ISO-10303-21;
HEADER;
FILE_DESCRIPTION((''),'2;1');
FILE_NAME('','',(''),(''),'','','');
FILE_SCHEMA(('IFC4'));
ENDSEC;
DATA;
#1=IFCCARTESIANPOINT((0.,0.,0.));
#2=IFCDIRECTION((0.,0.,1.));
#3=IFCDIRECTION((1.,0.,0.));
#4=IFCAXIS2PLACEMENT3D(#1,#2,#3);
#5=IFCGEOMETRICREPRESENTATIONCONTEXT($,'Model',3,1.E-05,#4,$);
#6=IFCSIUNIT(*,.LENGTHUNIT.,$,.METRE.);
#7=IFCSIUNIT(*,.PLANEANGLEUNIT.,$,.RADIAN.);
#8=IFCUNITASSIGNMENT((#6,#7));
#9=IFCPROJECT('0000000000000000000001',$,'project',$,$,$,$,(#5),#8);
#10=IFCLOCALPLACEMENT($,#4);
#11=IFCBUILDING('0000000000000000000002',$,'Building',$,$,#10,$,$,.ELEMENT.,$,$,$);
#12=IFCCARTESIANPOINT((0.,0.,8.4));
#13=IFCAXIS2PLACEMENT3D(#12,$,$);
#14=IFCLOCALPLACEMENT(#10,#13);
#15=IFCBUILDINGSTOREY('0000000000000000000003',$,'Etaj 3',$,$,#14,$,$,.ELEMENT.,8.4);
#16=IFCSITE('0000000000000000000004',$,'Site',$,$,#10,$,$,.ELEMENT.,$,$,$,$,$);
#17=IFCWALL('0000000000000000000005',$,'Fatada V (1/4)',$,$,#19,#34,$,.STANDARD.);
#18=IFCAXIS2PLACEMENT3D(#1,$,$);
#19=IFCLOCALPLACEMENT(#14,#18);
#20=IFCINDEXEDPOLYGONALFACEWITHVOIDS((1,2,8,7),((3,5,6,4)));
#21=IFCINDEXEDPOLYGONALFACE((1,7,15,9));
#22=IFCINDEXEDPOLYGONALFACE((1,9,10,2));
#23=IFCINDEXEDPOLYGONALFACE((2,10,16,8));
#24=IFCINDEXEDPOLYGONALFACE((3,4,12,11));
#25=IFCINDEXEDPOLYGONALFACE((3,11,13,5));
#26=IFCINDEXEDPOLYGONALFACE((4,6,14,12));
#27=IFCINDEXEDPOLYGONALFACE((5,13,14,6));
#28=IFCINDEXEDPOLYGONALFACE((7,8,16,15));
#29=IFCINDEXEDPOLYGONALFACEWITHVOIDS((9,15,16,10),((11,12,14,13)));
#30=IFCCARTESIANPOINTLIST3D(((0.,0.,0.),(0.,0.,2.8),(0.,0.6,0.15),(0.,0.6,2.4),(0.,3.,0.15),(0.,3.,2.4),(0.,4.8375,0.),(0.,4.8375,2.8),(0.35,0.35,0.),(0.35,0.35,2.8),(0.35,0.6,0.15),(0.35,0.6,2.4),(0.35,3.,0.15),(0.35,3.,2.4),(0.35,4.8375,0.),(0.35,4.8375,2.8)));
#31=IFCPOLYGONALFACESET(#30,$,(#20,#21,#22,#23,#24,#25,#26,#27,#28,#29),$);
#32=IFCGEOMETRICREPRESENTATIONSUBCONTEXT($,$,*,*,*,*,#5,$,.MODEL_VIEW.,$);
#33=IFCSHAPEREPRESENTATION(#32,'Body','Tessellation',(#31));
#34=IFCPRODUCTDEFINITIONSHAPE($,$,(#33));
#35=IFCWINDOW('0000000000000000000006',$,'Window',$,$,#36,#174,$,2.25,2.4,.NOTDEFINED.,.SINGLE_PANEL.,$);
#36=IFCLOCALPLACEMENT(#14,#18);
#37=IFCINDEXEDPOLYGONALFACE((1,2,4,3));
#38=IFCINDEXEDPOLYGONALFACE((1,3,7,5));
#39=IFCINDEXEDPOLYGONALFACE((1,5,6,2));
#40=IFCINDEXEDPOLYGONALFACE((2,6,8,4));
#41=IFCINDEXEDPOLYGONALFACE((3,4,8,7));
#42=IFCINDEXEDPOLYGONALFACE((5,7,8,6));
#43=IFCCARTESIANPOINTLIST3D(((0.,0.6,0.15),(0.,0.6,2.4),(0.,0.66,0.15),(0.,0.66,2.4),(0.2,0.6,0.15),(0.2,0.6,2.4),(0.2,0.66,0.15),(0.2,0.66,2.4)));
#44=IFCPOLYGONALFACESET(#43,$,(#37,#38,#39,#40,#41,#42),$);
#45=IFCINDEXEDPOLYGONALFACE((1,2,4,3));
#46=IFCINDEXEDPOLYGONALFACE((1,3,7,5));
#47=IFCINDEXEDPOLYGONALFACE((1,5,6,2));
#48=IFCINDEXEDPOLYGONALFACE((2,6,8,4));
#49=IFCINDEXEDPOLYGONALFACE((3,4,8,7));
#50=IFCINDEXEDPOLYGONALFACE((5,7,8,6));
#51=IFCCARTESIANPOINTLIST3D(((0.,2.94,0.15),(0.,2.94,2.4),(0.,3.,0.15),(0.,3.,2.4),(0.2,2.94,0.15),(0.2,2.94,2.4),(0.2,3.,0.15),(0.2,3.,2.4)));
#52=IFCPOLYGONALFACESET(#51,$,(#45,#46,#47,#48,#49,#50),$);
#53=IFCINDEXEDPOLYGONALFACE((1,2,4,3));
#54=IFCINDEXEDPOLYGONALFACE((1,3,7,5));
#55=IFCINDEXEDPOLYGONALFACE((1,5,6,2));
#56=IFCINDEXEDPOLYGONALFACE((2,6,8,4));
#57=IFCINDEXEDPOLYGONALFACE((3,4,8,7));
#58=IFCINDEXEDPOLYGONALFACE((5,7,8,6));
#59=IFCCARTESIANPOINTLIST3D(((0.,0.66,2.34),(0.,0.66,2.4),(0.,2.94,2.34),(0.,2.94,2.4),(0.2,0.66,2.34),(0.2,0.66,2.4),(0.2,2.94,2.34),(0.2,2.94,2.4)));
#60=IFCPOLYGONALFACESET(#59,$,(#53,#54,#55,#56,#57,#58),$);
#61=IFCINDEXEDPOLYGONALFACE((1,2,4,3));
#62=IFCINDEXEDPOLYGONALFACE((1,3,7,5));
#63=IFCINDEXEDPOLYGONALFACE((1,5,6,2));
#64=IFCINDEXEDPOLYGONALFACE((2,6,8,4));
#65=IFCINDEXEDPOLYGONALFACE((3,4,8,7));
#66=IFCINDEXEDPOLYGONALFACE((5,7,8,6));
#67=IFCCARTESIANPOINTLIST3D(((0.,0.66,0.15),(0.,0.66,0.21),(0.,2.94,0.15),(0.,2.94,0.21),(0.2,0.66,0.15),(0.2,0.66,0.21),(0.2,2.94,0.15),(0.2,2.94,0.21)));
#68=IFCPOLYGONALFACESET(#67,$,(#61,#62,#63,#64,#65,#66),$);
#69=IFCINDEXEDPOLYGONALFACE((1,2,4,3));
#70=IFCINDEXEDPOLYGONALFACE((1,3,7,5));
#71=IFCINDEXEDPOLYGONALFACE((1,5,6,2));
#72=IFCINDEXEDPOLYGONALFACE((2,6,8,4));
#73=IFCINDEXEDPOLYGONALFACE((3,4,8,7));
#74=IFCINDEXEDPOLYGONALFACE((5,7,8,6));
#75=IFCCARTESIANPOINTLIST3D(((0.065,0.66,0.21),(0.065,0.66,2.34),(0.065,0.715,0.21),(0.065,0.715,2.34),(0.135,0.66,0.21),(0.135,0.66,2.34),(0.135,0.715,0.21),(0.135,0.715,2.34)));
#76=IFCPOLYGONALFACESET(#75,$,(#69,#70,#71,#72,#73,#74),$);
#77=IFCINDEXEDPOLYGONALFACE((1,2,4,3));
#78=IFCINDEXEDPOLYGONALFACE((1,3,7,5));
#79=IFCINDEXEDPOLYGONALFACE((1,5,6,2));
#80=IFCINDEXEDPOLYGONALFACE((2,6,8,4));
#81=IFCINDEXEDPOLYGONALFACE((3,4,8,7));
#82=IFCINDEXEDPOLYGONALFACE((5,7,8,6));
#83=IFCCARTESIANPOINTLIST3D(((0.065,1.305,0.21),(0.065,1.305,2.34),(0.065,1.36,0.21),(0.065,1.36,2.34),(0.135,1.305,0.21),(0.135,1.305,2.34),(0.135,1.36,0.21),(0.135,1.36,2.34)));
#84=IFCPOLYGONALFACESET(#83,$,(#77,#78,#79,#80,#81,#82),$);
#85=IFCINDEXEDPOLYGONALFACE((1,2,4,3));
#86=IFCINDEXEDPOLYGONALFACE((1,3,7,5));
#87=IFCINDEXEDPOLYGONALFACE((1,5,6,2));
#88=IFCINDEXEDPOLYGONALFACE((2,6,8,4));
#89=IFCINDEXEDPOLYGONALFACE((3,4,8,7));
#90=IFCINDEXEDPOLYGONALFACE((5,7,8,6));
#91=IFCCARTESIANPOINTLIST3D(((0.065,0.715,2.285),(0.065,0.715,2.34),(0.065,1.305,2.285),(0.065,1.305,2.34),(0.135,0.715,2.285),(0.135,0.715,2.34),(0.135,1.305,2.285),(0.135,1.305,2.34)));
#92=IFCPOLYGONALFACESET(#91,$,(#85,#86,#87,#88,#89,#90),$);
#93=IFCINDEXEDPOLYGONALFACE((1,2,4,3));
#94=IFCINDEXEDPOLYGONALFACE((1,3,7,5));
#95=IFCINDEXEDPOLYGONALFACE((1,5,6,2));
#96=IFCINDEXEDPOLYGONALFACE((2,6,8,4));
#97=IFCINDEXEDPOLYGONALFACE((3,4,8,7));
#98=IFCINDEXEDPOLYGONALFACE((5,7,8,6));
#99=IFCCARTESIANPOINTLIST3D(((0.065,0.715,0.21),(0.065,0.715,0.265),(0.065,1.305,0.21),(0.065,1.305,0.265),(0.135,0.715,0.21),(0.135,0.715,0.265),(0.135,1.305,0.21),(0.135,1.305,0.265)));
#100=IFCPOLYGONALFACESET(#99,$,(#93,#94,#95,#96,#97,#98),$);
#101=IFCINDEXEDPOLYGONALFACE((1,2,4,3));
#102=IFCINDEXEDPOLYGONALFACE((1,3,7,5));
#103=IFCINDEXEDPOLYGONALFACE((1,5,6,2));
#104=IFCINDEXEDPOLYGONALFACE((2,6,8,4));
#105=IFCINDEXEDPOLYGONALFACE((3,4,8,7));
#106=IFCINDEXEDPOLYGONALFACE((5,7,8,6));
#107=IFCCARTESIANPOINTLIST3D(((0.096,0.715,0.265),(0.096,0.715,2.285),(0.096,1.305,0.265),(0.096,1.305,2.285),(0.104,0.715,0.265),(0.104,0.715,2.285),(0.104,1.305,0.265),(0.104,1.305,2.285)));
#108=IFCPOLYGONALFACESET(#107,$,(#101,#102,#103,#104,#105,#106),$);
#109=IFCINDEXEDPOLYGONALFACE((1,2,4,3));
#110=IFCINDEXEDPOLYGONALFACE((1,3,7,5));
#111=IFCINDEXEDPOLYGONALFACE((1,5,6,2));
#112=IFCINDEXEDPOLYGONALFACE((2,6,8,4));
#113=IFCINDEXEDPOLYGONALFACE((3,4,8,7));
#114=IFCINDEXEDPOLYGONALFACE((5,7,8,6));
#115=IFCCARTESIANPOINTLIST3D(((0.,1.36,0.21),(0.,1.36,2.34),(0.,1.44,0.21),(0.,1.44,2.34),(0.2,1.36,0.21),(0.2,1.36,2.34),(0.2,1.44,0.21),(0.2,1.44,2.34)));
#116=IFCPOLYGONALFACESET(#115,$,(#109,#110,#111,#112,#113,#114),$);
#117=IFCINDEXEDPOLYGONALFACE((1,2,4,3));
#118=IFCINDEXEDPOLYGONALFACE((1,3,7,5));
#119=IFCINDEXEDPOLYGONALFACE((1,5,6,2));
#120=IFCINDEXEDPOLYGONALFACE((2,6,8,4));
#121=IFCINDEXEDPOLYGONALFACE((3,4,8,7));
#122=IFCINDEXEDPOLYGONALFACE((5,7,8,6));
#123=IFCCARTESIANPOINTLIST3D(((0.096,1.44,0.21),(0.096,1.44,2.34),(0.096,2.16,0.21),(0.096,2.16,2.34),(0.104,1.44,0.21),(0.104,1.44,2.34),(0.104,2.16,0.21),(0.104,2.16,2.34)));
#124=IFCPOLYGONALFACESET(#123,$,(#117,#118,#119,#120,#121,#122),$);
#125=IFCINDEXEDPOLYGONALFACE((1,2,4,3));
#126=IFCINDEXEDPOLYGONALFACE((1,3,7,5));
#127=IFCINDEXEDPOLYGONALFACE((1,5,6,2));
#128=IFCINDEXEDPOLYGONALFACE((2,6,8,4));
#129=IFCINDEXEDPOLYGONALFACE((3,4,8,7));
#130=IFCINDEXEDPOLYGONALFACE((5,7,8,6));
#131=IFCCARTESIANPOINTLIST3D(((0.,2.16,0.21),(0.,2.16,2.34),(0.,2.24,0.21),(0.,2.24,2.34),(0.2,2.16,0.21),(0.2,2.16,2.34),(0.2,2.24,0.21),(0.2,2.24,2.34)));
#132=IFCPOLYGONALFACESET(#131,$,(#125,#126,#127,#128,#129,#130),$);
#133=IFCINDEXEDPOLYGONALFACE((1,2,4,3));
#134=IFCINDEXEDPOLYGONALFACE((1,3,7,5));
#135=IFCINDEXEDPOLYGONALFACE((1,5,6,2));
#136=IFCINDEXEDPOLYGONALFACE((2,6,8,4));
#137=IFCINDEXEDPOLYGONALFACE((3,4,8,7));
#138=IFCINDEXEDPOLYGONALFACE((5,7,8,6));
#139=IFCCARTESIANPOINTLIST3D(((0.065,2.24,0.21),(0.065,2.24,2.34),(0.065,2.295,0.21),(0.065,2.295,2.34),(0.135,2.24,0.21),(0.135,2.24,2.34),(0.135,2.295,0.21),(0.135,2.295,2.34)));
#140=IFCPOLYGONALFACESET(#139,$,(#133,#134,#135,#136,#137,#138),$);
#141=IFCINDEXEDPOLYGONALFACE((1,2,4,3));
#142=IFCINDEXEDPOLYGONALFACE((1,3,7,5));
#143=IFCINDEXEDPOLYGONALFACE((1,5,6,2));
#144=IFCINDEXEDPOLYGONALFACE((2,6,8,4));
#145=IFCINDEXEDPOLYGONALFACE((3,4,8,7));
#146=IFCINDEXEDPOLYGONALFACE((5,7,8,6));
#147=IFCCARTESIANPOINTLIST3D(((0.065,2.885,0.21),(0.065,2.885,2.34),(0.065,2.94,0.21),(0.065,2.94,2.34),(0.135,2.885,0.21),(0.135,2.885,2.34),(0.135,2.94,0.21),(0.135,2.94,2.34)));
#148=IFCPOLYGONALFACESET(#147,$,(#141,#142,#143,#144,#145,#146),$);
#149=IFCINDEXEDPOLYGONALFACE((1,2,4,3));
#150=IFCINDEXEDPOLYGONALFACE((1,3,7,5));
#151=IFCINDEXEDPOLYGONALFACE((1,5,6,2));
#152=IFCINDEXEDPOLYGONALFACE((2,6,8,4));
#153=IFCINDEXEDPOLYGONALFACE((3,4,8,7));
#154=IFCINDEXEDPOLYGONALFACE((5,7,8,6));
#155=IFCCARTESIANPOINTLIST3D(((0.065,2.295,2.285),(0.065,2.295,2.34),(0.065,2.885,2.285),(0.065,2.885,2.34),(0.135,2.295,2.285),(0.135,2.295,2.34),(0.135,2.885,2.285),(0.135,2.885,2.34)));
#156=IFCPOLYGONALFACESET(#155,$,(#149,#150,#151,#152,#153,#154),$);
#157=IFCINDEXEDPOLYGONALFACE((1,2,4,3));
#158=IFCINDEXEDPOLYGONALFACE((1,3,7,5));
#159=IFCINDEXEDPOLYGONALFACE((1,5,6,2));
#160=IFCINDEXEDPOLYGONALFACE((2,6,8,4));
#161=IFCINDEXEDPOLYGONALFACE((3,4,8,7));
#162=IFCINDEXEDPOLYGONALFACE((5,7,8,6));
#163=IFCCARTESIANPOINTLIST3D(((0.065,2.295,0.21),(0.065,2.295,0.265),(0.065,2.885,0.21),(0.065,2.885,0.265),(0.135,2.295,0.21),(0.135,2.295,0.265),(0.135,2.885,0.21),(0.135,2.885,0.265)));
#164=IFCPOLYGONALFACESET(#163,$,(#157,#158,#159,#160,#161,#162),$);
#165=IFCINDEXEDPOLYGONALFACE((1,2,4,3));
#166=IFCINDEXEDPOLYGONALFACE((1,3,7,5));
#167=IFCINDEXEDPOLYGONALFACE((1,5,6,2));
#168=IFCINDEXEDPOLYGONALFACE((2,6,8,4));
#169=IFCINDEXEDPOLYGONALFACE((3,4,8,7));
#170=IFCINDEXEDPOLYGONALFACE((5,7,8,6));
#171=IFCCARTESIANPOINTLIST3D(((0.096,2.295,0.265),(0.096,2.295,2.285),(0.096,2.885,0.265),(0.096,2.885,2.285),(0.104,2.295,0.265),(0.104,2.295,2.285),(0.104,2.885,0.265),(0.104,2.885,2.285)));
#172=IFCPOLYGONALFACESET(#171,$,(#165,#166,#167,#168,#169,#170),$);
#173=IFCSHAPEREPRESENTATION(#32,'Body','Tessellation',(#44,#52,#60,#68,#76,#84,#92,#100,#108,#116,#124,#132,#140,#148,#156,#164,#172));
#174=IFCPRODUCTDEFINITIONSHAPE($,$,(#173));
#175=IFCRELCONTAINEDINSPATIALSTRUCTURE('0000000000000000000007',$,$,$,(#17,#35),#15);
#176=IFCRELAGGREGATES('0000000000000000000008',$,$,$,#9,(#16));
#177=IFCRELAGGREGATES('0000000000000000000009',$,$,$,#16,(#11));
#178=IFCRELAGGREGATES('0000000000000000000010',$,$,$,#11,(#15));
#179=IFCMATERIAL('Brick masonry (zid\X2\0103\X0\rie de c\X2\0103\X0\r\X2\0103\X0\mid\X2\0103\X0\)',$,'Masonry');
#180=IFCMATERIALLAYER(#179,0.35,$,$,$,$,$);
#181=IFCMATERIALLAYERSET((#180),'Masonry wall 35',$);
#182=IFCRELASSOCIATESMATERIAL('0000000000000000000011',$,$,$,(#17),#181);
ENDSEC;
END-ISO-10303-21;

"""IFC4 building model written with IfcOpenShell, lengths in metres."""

from ifc_helpers import new_model, si_unit, frame, frame_2d, origin, origin_with_axes, origin_2d, place, context, subcontext, project, spatial, rectangle, extrude, clip, halfspace, material, layer, layer_set, layer_usage, element, fill, save


model = new_model("IFC4")

# Units and contexts
model_context = context("Model", 3, precision=1e-05, world=origin_with_axes())
sub_context = subcontext(model_context, None, None, "MODEL_VIEW")
ifc_project = project(units=[si_unit("LENGTHUNIT", "METRE"), si_unit("PLANEANGLEUNIT", "RADIAN")], contexts=[model_context])

# Site, building, storey
placement = place(None, origin_with_axes())
site = spatial("IfcSite", under=ifc_project, at=placement, Name="Site", CompositionType="ELEMENT")
building = spatial("IfcBuilding", under=site, at=placement, Name="Building", CompositionType="ELEMENT")
storey_placement = place(placement, frame((0.0, 0.0, 8.4)))
storey = spatial("IfcBuildingStorey", under=building, at=storey_placement, Name="Etaj 3", CompositionType="ELEMENT", Elevation=8.4)

# Wall, opening, window
ifc_material_1 = material(Name="Brick masonry (zidărie de cărămidă)", Category="Masonry")
ifc_layer_1 = layer(ifc_material_1, 0.35)
ifc_layer_set_1 = layer_set([ifc_layer_1], Name="Masonry wall 35")
ifc_layer_usage_1 = layer_usage(ifc_layer_set_1, "AXIS2", "POSITIVE", -0.175)
wall_1_placement = place(storey_placement, frame((0.175, 0.0, 0.0), x_axis=(0.0, 1.0, 0.0)))
wall_1 = element("IfcWall", 1, at=wall_1_placement, inside=storey, material=ifc_layer_usage_1, Name="Fatada V (1/4)", PredefinedType="STANDARD", context=sub_context, shape_type="CSG", body=[
    clip(extrude(rectangle(XDim=4.8375, YDim=0.35, at=frame_2d((2.4188, 0.0))), origin(), (0.0, 0.0, 1.0), 2.8), halfspace(frame((0.175, 0.0, 0.0), z_axis=(-0.707107, -0.707107, 0.0)), False)),
])
opening_1_placement = place(wall_1_placement, frame((1.8, 0.225, 0.15), z_axis=(0.0, -1.0, 0.0), x_axis=(1.0, 0.0, 0.0)))
opening_1 = element("IfcOpeningElement", 2, at=opening_1_placement, cuts=wall_1, PredefinedType="OPENING", context=sub_context, shape_type="SweptSolid", body=[
    extrude(rectangle(XDim=2.4, YDim=2.25, at=frame_2d((0.0, 1.125))), origin(), (0.0, 0.0, 1.0), 0.45),
])
window_1_placement = place(wall_1_placement, frame((1.8, 0.175, 0.15), z_axis=(0.0, -1.0, 0.0), x_axis=(1.0, 0.0, 0.0)))
window_1 = element("IfcWindow", 3, at=window_1_placement, inside=storey, Name="Window", OverallHeight=2.25, OverallWidth=2.4, PartitioningType="SINGLE_PANEL", PredefinedType="NOTDEFINED", context=sub_context, shape_type="SweptSolid", body=[
    extrude(rectangle(XDim=0.06, YDim=2.25, at=origin_2d()), frame((-1.17, 1.125, 0.0)), (0.0, 0.0, 1.0), 0.2),
    extrude(rectangle(XDim=0.06, YDim=2.25, at=origin_2d()), frame((1.17, 1.125, 0.0)), (0.0, 0.0, 1.0), 0.2),
    extrude(rectangle(XDim=2.28, YDim=0.06, at=origin_2d()), frame((0.0, 2.22, 0.0)), (0.0, 0.0, 1.0), 0.2),
    extrude(rectangle(XDim=2.28, YDim=0.06, at=origin_2d()), frame((0.0, 0.03, 0.0)), (0.0, 0.0, 1.0), 0.2),
    extrude(rectangle(XDim=0.055, YDim=2.13, at=origin_2d()), frame((-1.1125, 1.125, 0.065)), (0.0, 0.0, 1.0), 0.07),
    extrude(rectangle(XDim=0.055, YDim=2.13, at=origin_2d()), frame((-0.4675, 1.125, 0.065)), (0.0, 0.0, 1.0), 0.07),
    extrude(rectangle(XDim=0.59, YDim=0.055, at=origin_2d()), frame((-0.79, 2.1625, 0.065)), (0.0, 0.0, 1.0), 0.07),
    extrude(rectangle(XDim=0.59, YDim=0.055, at=origin_2d()), frame((-0.79, 0.0875, 0.065)), (0.0, 0.0, 1.0), 0.07),
    extrude(rectangle(XDim=0.59, YDim=2.02, at=origin_2d()), frame((-0.79, 1.125, 0.096)), (0.0, 0.0, 1.0), 0.008),
    extrude(rectangle(XDim=0.08, YDim=2.13, at=origin_2d()), frame((-0.4, 1.125, 0.0)), (0.0, 0.0, 1.0), 0.2),
    extrude(rectangle(XDim=0.72, YDim=2.13, at=origin_2d()), frame((0.0, 1.125, 0.096)), (0.0, 0.0, 1.0), 0.008),
    extrude(rectangle(XDim=0.08, YDim=2.13, at=origin_2d()), frame((0.4, 1.125, 0.0)), (0.0, 0.0, 1.0), 0.2),
    extrude(rectangle(XDim=0.055, YDim=2.13, at=origin_2d()), frame((0.4675, 1.125, 0.065)), (0.0, 0.0, 1.0), 0.07),
    extrude(rectangle(XDim=0.055, YDim=2.13, at=origin_2d()), frame((1.1125, 1.125, 0.065)), (0.0, 0.0, 1.0), 0.07),
    extrude(rectangle(XDim=0.59, YDim=0.055, at=origin_2d()), frame((0.79, 2.1625, 0.065)), (0.0, 0.0, 1.0), 0.07),
    extrude(rectangle(XDim=0.59, YDim=0.055, at=origin_2d()), frame((0.79, 0.0875, 0.065)), (0.0, 0.0, 1.0), 0.07),
    extrude(rectangle(XDim=0.59, YDim=2.02, at=origin_2d()), frame((0.79, 1.125, 0.096)), (0.0, 0.0, 1.0), 0.008),
])
fill(opening_1, window_1)

save(model, "model.ifc")
